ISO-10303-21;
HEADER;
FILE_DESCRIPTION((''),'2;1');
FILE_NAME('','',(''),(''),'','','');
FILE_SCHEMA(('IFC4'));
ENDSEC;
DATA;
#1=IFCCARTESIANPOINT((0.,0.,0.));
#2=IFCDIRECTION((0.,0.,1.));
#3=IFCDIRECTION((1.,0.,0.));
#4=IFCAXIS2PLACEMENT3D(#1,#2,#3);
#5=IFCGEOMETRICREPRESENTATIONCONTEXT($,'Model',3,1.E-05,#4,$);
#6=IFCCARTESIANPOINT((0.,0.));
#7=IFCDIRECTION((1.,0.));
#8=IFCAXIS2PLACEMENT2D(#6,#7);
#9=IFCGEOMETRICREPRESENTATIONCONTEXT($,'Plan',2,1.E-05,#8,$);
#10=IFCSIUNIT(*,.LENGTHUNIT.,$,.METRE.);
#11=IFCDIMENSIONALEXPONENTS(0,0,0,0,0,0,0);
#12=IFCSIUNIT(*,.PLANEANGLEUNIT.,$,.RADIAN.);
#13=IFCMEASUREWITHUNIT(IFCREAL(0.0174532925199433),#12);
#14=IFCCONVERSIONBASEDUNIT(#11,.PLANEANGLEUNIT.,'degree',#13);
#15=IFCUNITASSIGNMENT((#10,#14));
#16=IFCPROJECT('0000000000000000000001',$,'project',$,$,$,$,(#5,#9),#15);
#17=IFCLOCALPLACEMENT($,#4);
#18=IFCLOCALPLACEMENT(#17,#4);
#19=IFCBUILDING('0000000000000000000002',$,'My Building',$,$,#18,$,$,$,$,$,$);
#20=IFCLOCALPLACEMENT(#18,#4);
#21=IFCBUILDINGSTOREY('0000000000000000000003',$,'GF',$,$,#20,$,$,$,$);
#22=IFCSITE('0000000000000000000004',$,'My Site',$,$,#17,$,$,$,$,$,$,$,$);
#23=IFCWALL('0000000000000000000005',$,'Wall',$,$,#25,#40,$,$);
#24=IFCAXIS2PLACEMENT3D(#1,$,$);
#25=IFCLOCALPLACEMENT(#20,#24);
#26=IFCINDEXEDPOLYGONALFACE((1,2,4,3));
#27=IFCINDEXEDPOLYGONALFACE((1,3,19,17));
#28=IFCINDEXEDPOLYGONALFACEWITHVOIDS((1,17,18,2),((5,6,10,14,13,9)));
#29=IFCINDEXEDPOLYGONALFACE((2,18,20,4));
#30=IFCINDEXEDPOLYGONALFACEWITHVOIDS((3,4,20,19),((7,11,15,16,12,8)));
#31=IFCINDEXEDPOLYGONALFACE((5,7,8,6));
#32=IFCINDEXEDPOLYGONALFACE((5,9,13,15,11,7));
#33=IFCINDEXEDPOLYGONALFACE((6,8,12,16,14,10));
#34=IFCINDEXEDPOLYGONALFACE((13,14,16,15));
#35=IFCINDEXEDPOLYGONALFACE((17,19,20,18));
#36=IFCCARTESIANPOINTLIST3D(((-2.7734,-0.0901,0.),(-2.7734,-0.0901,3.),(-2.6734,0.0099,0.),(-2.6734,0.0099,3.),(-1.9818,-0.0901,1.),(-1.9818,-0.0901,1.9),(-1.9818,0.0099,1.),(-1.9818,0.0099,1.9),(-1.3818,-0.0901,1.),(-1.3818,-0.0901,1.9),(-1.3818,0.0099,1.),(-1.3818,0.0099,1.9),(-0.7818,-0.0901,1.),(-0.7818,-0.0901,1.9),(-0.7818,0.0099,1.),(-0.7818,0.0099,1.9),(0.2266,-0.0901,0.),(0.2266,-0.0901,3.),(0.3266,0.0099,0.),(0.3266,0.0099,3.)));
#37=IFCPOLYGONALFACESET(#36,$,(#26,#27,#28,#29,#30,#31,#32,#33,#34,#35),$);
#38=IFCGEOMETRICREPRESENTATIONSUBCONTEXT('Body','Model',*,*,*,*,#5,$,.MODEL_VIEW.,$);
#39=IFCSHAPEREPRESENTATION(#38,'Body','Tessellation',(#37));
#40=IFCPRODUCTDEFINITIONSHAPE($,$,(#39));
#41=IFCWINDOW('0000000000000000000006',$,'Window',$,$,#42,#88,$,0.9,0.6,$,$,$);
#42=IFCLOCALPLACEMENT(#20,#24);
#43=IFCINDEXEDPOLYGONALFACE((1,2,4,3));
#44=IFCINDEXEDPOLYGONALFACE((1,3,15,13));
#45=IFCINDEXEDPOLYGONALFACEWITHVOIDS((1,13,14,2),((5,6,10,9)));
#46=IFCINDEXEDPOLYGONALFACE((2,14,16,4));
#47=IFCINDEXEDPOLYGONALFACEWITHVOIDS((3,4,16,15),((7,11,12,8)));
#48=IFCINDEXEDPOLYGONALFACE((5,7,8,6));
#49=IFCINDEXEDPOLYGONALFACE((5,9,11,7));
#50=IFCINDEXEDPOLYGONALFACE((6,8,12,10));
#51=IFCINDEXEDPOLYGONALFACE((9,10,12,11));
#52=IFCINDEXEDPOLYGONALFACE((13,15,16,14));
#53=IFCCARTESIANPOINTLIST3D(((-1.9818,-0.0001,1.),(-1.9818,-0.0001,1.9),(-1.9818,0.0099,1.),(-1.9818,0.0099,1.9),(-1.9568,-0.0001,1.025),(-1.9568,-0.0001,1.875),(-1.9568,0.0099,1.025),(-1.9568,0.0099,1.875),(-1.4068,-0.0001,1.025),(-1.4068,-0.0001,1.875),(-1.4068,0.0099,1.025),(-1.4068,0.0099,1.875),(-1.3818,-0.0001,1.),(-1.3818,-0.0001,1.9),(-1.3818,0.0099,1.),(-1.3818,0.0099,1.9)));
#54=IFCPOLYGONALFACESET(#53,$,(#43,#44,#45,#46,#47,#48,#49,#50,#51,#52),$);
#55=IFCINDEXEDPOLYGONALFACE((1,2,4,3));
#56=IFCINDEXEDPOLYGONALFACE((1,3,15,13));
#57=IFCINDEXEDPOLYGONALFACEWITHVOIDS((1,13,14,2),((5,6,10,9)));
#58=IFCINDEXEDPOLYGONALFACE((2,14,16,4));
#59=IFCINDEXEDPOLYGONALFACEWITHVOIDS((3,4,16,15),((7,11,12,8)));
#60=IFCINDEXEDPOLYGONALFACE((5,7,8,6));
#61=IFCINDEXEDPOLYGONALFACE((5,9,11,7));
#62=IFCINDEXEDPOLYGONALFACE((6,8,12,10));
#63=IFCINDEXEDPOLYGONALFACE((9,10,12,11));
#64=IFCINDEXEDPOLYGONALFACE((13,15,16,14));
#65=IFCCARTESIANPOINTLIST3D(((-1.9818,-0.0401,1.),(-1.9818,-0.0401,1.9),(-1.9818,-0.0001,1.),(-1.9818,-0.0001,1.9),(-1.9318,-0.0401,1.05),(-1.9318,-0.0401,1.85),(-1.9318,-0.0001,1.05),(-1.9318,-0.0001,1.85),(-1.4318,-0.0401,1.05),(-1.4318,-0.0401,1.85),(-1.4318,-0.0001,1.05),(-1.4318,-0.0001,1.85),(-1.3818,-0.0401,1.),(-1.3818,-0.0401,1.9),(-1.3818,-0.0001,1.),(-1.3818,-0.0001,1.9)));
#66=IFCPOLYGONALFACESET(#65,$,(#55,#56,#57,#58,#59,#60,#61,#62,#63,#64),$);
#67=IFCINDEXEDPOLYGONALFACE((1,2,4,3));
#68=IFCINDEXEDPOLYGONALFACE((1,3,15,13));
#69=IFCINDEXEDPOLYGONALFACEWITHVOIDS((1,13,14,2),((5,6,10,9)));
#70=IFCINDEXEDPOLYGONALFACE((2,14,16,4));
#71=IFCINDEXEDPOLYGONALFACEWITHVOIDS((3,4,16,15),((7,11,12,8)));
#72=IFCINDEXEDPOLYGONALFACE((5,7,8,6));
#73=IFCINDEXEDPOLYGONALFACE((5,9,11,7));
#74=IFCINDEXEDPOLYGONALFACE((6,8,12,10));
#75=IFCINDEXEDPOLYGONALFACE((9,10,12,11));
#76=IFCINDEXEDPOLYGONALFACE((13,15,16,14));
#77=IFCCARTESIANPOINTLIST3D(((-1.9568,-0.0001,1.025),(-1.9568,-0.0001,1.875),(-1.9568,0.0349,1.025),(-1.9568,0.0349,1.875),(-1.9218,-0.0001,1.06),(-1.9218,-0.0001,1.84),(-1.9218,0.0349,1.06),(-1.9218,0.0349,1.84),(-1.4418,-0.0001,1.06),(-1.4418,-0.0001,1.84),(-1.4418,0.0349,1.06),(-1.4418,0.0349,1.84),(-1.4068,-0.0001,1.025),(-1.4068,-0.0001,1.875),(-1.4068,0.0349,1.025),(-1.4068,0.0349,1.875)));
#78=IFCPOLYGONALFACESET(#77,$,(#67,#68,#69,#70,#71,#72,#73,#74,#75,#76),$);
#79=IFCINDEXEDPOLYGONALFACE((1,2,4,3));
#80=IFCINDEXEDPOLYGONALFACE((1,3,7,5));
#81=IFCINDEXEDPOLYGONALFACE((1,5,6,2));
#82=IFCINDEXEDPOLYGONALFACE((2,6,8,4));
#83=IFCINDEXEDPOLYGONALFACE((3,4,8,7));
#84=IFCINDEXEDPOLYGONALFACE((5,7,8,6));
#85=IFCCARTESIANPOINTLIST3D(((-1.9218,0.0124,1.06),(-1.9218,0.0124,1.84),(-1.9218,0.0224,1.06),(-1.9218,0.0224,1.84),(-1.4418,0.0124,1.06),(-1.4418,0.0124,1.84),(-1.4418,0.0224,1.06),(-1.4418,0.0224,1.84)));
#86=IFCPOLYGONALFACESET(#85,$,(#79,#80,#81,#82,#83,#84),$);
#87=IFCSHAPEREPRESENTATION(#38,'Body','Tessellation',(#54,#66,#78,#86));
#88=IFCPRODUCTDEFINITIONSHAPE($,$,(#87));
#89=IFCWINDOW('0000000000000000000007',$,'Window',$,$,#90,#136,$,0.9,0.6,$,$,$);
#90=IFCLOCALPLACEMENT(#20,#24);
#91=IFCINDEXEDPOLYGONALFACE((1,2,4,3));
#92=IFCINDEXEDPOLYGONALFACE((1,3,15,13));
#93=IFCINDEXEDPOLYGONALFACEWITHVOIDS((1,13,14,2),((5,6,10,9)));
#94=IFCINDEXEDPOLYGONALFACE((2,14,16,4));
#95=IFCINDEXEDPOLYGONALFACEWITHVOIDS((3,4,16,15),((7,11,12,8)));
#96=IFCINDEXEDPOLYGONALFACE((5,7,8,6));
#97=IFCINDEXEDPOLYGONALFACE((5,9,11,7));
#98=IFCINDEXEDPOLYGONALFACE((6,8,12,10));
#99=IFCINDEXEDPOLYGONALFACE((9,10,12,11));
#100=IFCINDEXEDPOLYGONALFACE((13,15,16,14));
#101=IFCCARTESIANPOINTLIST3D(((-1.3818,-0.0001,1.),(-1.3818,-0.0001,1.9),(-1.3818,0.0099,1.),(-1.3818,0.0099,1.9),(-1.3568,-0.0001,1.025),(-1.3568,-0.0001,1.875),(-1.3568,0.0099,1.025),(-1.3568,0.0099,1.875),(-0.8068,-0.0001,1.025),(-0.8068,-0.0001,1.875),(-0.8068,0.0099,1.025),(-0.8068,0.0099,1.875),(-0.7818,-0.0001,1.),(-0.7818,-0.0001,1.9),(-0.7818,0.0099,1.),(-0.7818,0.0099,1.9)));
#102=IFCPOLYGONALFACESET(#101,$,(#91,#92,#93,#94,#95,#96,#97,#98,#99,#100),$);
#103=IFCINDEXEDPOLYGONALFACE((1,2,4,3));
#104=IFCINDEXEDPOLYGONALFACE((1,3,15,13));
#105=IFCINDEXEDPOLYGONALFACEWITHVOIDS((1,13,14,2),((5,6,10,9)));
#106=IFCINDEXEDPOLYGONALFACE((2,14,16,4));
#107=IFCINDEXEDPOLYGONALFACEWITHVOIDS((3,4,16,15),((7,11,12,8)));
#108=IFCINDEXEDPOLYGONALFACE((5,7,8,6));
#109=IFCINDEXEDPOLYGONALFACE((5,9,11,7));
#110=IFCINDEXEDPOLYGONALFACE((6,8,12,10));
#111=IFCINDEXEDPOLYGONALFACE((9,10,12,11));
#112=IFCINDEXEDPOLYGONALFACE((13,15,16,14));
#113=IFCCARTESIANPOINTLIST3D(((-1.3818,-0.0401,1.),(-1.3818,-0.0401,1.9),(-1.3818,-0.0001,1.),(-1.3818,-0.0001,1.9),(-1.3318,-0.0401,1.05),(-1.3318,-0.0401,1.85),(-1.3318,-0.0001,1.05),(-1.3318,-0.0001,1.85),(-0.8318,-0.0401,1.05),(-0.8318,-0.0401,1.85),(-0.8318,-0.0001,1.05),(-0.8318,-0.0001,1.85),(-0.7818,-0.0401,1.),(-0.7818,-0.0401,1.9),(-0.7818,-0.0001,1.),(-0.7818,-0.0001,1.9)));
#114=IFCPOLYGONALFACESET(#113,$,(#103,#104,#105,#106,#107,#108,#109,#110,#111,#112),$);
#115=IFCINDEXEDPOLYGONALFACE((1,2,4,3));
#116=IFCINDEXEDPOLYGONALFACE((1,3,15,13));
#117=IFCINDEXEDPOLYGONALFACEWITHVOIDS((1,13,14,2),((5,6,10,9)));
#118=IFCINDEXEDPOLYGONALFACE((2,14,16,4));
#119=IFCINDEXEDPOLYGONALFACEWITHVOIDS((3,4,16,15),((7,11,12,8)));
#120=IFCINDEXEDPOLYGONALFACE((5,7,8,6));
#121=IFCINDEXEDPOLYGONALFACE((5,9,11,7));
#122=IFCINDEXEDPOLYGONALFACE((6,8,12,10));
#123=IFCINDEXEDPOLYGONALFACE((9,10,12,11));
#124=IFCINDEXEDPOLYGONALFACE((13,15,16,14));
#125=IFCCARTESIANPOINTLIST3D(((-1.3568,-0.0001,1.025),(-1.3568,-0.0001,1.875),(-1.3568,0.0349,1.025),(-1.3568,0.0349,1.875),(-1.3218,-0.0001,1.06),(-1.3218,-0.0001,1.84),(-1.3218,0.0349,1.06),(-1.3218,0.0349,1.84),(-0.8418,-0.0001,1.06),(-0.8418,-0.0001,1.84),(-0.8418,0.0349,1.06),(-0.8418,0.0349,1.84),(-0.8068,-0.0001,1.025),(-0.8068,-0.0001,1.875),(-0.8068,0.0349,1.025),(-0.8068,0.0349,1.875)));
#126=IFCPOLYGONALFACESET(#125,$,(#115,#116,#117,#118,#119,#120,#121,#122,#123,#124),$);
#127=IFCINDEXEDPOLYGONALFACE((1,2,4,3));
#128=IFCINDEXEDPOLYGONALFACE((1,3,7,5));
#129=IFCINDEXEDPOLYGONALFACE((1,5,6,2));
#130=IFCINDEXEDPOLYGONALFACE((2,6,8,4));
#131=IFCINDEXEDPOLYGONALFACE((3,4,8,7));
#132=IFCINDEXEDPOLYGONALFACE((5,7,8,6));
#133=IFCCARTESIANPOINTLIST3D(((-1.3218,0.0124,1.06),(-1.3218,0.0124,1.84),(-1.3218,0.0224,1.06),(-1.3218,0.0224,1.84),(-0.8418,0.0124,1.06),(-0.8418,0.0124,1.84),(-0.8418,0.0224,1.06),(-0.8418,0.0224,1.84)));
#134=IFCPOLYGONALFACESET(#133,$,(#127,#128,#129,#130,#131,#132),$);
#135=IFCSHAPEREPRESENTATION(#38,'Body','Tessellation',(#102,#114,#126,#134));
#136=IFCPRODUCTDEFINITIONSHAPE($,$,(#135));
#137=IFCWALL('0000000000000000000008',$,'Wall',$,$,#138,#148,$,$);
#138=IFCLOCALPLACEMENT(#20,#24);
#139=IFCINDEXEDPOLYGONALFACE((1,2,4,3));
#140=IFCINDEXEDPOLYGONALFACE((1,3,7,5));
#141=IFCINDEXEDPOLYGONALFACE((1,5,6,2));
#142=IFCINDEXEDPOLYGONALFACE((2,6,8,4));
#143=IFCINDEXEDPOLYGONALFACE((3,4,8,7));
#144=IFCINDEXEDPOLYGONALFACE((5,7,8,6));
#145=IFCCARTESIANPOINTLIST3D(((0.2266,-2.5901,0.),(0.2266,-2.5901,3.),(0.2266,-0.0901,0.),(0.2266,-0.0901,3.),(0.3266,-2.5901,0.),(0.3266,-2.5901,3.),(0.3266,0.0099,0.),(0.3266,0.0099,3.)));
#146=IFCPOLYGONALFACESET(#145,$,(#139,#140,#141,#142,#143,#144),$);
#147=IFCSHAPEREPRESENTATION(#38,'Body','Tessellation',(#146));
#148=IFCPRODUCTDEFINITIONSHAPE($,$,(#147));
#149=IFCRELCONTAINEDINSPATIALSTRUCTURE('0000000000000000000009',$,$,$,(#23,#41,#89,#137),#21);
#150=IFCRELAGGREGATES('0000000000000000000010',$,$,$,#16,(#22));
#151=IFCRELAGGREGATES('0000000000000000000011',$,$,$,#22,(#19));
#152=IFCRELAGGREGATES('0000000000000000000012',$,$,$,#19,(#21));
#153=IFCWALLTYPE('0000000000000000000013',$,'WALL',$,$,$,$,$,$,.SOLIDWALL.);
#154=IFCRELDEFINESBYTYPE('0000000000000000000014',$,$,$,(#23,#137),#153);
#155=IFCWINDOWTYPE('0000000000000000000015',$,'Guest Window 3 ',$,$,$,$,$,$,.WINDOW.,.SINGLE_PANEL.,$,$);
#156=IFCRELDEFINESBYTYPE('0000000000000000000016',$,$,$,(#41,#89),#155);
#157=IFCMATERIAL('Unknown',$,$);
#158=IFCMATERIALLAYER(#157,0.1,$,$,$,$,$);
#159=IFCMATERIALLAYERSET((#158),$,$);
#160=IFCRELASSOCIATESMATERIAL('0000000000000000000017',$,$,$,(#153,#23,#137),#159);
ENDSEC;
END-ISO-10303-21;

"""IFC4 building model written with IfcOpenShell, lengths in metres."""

from ifc_helpers import new_model, entity, si_unit, converted_unit, frame, origin_with_axes, origin_2d_with_axis, place, context, subcontext, project, spatial, line, indexed_curve, outline, extrude, shape, source, transform, mapped, material, layer, layer_set, layer_usage, type_object, type_shapes, element, fill, save


model = new_model("IFC4")

# Units and contexts
model_context = context("Model", 3, precision=1e-05, world=origin_with_axes())
plan_context = context("Plan", 2, precision=1e-05, world=origin_2d_with_axis())
body_context_1 = subcontext(model_context, "Body", "Model", "MODEL_VIEW")
body_context_2 = subcontext(plan_context, "Body", "Plan", "PLAN_VIEW")
ifc_project = project(units=[si_unit("LENGTHUNIT", "METRE"), converted_unit("PLANEANGLEUNIT", "degree", entity("IfcReal", 0.0174532925199433), si_unit("PLANEANGLEUNIT", "RADIAN"), dimensions=[0, 0, 0, 0, 0, 0, 0])], contexts=[model_context, plan_context])

# Site, building, storey
site_placement = place(None, origin_with_axes())
site = spatial("IfcSite", under=ifc_project, at=site_placement, Name="My Site")
building_placement = place(site_placement, origin_with_axes())
building = spatial("IfcBuilding", under=site, at=building_placement, Name="My Building")
storey_placement = place(building_placement, origin_with_axes())
storey = spatial("IfcBuildingStorey", under=building, at=storey_placement, Name="GF")

# Shared definitions
ifc_material_1 = material(Name="Unknown")

# Shared definitions
ifc_layer_1 = layer(ifc_material_1, 0.1)
ifc_layer_set_1 = layer_set([ifc_layer_1])
wall_type = type_object("IfcWallType", Name="WALL", PredefinedType="SOLIDWALL", material=ifc_layer_set_1)

# Wall, openings, windows
ifc_layer_usage_1 = layer_usage(ifc_layer_set_1, "AXIS2", "POSITIVE", 0.0)
wall_1_placement = place(storey_placement, frame((-2.7734, -0.0901, 0.0), z_axis=(0.0, 0.0, 1.0), x_axis=(1.0, 0.0, 0.0)))
wall_1 = element("IfcWall", 1, at=wall_1_placement, inside=storey, type_object=wall_type, material=ifc_layer_usage_1, Name="Wall", context=body_context_1, shape_type="SweptSolid", body=[
    extrude(outline(indexed_curve([(0.0, 0.0), (0.1, 0.1), (3.1, 0.1), (3.0, 0.0)], segments=[line(1, 2, 3, 4, 1)])), origin_with_axes(), (0.0, 0.0, 1.0), 3.0),
])
shared_shape_1 = source(origin_with_axes(), body_context_1, "Body", "SweptSolid", [
    extrude(outline(indexed_curve([(0.0, 0.0), (0.6, 0.0), (0.6, 0.9), (0.0, 0.9)], segments=[line(1, 2, 3, 4, 1)])), frame((0.0, -0.6, 0.0), z_axis=(0.0, -1.0, 0.0), x_axis=(1.0, 0.0, 0.0)), (0.0, 0.0, -1.0), 1.2),
])
opening_1_placement = place(wall_1_placement, frame((0.7916, 0.0, 1.0), z_axis=(0.0, 0.0, 1.0), x_axis=(1.0, 0.0, 0.0)))
opening_1 = element("IfcOpeningElement", 2, at=opening_1_placement, cuts=wall_1, PredefinedType="OPENING", context=body_context_1, shape_type="MappedRepresentation", body=[
    mapped(shared_shape_1, transform((0.0, 0.0, 0.0), x_axis=(1.0, 0.0, 0.0), y_axis=(0.0, 1.0, 0.0), z_axis=(0.0, 0.0, 1.0), scale=1.0)),
])
opening_2_placement = place(wall_1_placement, frame((1.3916, 0.0, 1.0), z_axis=(0.0, 0.0, 1.0), x_axis=(1.0, 0.0, 0.0)))
opening_2 = element("IfcOpeningElement", 3, at=opening_2_placement, cuts=wall_1, PredefinedType="OPENING", context=body_context_1, shape_type="MappedRepresentation", body=[
    mapped(shared_shape_1, transform((0.0, 0.0, 0.0), x_axis=(1.0, 0.0, 0.0), y_axis=(0.0, 1.0, 0.0), z_axis=(0.0, 0.0, 1.0), scale=1.0)),
])
window_type_1 = type_object("IfcWindowType", Name="Guest Window 3 ", PartitioningType="SINGLE_PANEL", PredefinedType="WINDOW")
shared_shape_2 = source(origin_with_axes(), body_context_1, "Body", "SweptSolid", [
    extrude(outline(indexed_curve([(0.0, 0.0), (0.6, 0.0), (0.6, 0.9), (0.0, 0.9)], segments=[line(1, 2, 3, 4, 1)]), holes=[indexed_curve([(0.025, 0.025), (0.575, 0.025), (0.575, 0.875), (0.025, 0.875)], segments=[line(1, 2, 3, 4, 1)])]), frame((0.0, 0.09, 0.0), z_axis=(0.0, -1.0, 0.0), x_axis=(1.0, 0.0, 0.0)), (0.0, 0.0, -1.0), 0.01),
    extrude(outline(indexed_curve([(0.0, 0.0), (0.6, 0.0), (0.6, 0.9), (0.0, 0.9)], segments=[line(1, 2, 3, 4, 1)]), holes=[indexed_curve([(0.05, 0.05), (0.55, 0.05), (0.55, 0.85), (0.05, 0.85)], segments=[line(1, 2, 3, 4, 1)])]), frame((0.0, 0.05, 0.0), z_axis=(0.0, -1.0, 0.0), x_axis=(1.0, 0.0, 0.0)), (0.0, 0.0, -1.0), 0.04),
    extrude(outline(indexed_curve([(0.0, 0.0), (0.55, 0.0), (0.55, 0.85), (0.0, 0.85)], segments=[line(1, 2, 3, 4, 1)]), holes=[indexed_curve([(0.035, 0.035), (0.515, 0.035), (0.515, 0.815), (0.035, 0.815)], segments=[line(1, 2, 3, 4, 1)])]), frame((0.025, 0.09, 0.025), z_axis=(0.0, -1.0, 0.0), x_axis=(1.0, 0.0, 0.0)), (0.0, 0.0, -1.0), 0.035),
    extrude(outline(indexed_curve([(0.035, 0.035), (0.515, 0.035), (0.515, 0.815), (0.035, 0.815)], segments=[line(1, 2, 3, 4, 1)])), frame((0.025, 0.1025, 0.025), z_axis=(0.0, -1.0, 0.0), x_axis=(1.0, 0.0, 0.0)), (0.0, 0.0, -1.0), 0.01),
])
shared_shape_3 = source(origin_with_axes(), body_context_2, "Body", "Curve2D", [
    entity("IfcIndexedPolyCurve", entity("IfcCartesianPointList2D", [[0.05, 0.05], [0.55, 0.05]])),
    entity("IfcIndexedPolyCurve", entity("IfcCartesianPointList2D", [[0.0, 0.1], [0.025, 0.1], [0.025, 0.09], [0.05, 0.09], [0.05, 0.05], [0.0, 0.05]]), [entity("IfcLineIndex", [1, 2, 3, 4, 5, 6, 1])]),
    entity("IfcIndexedPolyCurve", entity("IfcCartesianPointList2D", [[0.6, 0.1], [0.575, 0.1], [0.575, 0.09], [0.55, 0.09], [0.55, 0.05], [0.6, 0.05]]), [entity("IfcLineIndex", [1, 2, 3, 4, 5, 6, 1])]),
    entity("IfcIndexedPolyCurve", entity("IfcCartesianPointList2D", [[0.025, 0.09], [0.06, 0.09], [0.06, 0.125], [0.025, 0.125]]), [entity("IfcLineIndex", [1, 2, 3, 4, 1])]),
    entity("IfcIndexedPolyCurve", entity("IfcCartesianPointList2D", [[0.575, 0.09], [0.54, 0.09], [0.54, 0.125], [0.575, 0.125]]), [entity("IfcLineIndex", [1, 2, 3, 4, 1])]),
    entity("IfcIndexedPolyCurve", entity("IfcCartesianPointList2D", [[0.06, 0.09], [0.54, 0.09]])),
    entity("IfcIndexedPolyCurve", entity("IfcCartesianPointList2D", [[0.06, 0.125], [0.54, 0.125]])),
    entity("IfcIndexedPolyCurve", entity("IfcCartesianPointList2D", [[0.06, 0.1075], [0.54, 0.1075]])),
])
type_shapes(window_type_1, [shared_shape_2, shared_shape_3])
window_1_placement = place(opening_1_placement, origin_with_axes())
window_1 = element("IfcWindow", 4, at=window_1_placement, inside=storey, type_object=window_type_1, Name="Window", OverallHeight=0.9, OverallWidth=0.6, shapes=[
    shape(body_context_1, "Body", "MappedRepresentation", [mapped(shared_shape_2, transform((0.0, 0.0, 0.0), x_axis=(1.0, 0.0, 0.0), y_axis=(0.0, 1.0, 0.0), z_axis=(0.0, 0.0, 1.0), scale=1.0))]),
    shape(body_context_2, "Body", "MappedRepresentation", [mapped(shared_shape_3, transform((0.0, 0.0, 0.0), x_axis=(1.0, 0.0, 0.0), y_axis=(0.0, 1.0, 0.0), z_axis=(0.0, 0.0, 1.0), scale=1.0))]),
])
fill(opening_1, window_1)
window_2_placement = place(opening_2_placement, origin_with_axes())
window_2 = element("IfcWindow", 5, at=window_2_placement, inside=storey, type_object=window_type_1, Name="Window", OverallHeight=0.9, OverallWidth=0.6, shapes=[
    shape(body_context_1, "Body", "MappedRepresentation", [mapped(shared_shape_2, transform((0.0, 0.0, 0.0), x_axis=(1.0, 0.0, 0.0), y_axis=(0.0, 1.0, 0.0), z_axis=(0.0, 0.0, 1.0), scale=1.0))]),
    shape(body_context_2, "Body", "MappedRepresentation", [mapped(shared_shape_3, transform((0.0, 0.0, 0.0), x_axis=(1.0, 0.0, 0.0), y_axis=(0.0, 1.0, 0.0), z_axis=(0.0, 0.0, 1.0), scale=1.0))]),
])
fill(opening_2, window_2)

# Wall
ifc_layer_usage_2 = layer_usage(ifc_layer_set_1, "AXIS2", "POSITIVE", 0.0)
wall_2_placement = place(storey_placement, frame((0.2266, -0.0901, 0.0), z_axis=(0.0, 0.0, 1.0), x_axis=(0.0, -1.0, 0.0)))
element("IfcWall", 6, at=wall_2_placement, inside=storey, type_object=wall_type, material=ifc_layer_usage_2, Name="Wall", context=body_context_1, shape_type="SweptSolid", body=[
    extrude(outline(indexed_curve([(0.0, 0.0), (-0.1, 0.1), (2.5, 0.1), (2.5, 0.0)], segments=[line(1, 2, 3, 4, 1)])), origin_with_axes(), (0.0, 0.0, 1.0), 3.0),
])

save(model, "model.ifc")
